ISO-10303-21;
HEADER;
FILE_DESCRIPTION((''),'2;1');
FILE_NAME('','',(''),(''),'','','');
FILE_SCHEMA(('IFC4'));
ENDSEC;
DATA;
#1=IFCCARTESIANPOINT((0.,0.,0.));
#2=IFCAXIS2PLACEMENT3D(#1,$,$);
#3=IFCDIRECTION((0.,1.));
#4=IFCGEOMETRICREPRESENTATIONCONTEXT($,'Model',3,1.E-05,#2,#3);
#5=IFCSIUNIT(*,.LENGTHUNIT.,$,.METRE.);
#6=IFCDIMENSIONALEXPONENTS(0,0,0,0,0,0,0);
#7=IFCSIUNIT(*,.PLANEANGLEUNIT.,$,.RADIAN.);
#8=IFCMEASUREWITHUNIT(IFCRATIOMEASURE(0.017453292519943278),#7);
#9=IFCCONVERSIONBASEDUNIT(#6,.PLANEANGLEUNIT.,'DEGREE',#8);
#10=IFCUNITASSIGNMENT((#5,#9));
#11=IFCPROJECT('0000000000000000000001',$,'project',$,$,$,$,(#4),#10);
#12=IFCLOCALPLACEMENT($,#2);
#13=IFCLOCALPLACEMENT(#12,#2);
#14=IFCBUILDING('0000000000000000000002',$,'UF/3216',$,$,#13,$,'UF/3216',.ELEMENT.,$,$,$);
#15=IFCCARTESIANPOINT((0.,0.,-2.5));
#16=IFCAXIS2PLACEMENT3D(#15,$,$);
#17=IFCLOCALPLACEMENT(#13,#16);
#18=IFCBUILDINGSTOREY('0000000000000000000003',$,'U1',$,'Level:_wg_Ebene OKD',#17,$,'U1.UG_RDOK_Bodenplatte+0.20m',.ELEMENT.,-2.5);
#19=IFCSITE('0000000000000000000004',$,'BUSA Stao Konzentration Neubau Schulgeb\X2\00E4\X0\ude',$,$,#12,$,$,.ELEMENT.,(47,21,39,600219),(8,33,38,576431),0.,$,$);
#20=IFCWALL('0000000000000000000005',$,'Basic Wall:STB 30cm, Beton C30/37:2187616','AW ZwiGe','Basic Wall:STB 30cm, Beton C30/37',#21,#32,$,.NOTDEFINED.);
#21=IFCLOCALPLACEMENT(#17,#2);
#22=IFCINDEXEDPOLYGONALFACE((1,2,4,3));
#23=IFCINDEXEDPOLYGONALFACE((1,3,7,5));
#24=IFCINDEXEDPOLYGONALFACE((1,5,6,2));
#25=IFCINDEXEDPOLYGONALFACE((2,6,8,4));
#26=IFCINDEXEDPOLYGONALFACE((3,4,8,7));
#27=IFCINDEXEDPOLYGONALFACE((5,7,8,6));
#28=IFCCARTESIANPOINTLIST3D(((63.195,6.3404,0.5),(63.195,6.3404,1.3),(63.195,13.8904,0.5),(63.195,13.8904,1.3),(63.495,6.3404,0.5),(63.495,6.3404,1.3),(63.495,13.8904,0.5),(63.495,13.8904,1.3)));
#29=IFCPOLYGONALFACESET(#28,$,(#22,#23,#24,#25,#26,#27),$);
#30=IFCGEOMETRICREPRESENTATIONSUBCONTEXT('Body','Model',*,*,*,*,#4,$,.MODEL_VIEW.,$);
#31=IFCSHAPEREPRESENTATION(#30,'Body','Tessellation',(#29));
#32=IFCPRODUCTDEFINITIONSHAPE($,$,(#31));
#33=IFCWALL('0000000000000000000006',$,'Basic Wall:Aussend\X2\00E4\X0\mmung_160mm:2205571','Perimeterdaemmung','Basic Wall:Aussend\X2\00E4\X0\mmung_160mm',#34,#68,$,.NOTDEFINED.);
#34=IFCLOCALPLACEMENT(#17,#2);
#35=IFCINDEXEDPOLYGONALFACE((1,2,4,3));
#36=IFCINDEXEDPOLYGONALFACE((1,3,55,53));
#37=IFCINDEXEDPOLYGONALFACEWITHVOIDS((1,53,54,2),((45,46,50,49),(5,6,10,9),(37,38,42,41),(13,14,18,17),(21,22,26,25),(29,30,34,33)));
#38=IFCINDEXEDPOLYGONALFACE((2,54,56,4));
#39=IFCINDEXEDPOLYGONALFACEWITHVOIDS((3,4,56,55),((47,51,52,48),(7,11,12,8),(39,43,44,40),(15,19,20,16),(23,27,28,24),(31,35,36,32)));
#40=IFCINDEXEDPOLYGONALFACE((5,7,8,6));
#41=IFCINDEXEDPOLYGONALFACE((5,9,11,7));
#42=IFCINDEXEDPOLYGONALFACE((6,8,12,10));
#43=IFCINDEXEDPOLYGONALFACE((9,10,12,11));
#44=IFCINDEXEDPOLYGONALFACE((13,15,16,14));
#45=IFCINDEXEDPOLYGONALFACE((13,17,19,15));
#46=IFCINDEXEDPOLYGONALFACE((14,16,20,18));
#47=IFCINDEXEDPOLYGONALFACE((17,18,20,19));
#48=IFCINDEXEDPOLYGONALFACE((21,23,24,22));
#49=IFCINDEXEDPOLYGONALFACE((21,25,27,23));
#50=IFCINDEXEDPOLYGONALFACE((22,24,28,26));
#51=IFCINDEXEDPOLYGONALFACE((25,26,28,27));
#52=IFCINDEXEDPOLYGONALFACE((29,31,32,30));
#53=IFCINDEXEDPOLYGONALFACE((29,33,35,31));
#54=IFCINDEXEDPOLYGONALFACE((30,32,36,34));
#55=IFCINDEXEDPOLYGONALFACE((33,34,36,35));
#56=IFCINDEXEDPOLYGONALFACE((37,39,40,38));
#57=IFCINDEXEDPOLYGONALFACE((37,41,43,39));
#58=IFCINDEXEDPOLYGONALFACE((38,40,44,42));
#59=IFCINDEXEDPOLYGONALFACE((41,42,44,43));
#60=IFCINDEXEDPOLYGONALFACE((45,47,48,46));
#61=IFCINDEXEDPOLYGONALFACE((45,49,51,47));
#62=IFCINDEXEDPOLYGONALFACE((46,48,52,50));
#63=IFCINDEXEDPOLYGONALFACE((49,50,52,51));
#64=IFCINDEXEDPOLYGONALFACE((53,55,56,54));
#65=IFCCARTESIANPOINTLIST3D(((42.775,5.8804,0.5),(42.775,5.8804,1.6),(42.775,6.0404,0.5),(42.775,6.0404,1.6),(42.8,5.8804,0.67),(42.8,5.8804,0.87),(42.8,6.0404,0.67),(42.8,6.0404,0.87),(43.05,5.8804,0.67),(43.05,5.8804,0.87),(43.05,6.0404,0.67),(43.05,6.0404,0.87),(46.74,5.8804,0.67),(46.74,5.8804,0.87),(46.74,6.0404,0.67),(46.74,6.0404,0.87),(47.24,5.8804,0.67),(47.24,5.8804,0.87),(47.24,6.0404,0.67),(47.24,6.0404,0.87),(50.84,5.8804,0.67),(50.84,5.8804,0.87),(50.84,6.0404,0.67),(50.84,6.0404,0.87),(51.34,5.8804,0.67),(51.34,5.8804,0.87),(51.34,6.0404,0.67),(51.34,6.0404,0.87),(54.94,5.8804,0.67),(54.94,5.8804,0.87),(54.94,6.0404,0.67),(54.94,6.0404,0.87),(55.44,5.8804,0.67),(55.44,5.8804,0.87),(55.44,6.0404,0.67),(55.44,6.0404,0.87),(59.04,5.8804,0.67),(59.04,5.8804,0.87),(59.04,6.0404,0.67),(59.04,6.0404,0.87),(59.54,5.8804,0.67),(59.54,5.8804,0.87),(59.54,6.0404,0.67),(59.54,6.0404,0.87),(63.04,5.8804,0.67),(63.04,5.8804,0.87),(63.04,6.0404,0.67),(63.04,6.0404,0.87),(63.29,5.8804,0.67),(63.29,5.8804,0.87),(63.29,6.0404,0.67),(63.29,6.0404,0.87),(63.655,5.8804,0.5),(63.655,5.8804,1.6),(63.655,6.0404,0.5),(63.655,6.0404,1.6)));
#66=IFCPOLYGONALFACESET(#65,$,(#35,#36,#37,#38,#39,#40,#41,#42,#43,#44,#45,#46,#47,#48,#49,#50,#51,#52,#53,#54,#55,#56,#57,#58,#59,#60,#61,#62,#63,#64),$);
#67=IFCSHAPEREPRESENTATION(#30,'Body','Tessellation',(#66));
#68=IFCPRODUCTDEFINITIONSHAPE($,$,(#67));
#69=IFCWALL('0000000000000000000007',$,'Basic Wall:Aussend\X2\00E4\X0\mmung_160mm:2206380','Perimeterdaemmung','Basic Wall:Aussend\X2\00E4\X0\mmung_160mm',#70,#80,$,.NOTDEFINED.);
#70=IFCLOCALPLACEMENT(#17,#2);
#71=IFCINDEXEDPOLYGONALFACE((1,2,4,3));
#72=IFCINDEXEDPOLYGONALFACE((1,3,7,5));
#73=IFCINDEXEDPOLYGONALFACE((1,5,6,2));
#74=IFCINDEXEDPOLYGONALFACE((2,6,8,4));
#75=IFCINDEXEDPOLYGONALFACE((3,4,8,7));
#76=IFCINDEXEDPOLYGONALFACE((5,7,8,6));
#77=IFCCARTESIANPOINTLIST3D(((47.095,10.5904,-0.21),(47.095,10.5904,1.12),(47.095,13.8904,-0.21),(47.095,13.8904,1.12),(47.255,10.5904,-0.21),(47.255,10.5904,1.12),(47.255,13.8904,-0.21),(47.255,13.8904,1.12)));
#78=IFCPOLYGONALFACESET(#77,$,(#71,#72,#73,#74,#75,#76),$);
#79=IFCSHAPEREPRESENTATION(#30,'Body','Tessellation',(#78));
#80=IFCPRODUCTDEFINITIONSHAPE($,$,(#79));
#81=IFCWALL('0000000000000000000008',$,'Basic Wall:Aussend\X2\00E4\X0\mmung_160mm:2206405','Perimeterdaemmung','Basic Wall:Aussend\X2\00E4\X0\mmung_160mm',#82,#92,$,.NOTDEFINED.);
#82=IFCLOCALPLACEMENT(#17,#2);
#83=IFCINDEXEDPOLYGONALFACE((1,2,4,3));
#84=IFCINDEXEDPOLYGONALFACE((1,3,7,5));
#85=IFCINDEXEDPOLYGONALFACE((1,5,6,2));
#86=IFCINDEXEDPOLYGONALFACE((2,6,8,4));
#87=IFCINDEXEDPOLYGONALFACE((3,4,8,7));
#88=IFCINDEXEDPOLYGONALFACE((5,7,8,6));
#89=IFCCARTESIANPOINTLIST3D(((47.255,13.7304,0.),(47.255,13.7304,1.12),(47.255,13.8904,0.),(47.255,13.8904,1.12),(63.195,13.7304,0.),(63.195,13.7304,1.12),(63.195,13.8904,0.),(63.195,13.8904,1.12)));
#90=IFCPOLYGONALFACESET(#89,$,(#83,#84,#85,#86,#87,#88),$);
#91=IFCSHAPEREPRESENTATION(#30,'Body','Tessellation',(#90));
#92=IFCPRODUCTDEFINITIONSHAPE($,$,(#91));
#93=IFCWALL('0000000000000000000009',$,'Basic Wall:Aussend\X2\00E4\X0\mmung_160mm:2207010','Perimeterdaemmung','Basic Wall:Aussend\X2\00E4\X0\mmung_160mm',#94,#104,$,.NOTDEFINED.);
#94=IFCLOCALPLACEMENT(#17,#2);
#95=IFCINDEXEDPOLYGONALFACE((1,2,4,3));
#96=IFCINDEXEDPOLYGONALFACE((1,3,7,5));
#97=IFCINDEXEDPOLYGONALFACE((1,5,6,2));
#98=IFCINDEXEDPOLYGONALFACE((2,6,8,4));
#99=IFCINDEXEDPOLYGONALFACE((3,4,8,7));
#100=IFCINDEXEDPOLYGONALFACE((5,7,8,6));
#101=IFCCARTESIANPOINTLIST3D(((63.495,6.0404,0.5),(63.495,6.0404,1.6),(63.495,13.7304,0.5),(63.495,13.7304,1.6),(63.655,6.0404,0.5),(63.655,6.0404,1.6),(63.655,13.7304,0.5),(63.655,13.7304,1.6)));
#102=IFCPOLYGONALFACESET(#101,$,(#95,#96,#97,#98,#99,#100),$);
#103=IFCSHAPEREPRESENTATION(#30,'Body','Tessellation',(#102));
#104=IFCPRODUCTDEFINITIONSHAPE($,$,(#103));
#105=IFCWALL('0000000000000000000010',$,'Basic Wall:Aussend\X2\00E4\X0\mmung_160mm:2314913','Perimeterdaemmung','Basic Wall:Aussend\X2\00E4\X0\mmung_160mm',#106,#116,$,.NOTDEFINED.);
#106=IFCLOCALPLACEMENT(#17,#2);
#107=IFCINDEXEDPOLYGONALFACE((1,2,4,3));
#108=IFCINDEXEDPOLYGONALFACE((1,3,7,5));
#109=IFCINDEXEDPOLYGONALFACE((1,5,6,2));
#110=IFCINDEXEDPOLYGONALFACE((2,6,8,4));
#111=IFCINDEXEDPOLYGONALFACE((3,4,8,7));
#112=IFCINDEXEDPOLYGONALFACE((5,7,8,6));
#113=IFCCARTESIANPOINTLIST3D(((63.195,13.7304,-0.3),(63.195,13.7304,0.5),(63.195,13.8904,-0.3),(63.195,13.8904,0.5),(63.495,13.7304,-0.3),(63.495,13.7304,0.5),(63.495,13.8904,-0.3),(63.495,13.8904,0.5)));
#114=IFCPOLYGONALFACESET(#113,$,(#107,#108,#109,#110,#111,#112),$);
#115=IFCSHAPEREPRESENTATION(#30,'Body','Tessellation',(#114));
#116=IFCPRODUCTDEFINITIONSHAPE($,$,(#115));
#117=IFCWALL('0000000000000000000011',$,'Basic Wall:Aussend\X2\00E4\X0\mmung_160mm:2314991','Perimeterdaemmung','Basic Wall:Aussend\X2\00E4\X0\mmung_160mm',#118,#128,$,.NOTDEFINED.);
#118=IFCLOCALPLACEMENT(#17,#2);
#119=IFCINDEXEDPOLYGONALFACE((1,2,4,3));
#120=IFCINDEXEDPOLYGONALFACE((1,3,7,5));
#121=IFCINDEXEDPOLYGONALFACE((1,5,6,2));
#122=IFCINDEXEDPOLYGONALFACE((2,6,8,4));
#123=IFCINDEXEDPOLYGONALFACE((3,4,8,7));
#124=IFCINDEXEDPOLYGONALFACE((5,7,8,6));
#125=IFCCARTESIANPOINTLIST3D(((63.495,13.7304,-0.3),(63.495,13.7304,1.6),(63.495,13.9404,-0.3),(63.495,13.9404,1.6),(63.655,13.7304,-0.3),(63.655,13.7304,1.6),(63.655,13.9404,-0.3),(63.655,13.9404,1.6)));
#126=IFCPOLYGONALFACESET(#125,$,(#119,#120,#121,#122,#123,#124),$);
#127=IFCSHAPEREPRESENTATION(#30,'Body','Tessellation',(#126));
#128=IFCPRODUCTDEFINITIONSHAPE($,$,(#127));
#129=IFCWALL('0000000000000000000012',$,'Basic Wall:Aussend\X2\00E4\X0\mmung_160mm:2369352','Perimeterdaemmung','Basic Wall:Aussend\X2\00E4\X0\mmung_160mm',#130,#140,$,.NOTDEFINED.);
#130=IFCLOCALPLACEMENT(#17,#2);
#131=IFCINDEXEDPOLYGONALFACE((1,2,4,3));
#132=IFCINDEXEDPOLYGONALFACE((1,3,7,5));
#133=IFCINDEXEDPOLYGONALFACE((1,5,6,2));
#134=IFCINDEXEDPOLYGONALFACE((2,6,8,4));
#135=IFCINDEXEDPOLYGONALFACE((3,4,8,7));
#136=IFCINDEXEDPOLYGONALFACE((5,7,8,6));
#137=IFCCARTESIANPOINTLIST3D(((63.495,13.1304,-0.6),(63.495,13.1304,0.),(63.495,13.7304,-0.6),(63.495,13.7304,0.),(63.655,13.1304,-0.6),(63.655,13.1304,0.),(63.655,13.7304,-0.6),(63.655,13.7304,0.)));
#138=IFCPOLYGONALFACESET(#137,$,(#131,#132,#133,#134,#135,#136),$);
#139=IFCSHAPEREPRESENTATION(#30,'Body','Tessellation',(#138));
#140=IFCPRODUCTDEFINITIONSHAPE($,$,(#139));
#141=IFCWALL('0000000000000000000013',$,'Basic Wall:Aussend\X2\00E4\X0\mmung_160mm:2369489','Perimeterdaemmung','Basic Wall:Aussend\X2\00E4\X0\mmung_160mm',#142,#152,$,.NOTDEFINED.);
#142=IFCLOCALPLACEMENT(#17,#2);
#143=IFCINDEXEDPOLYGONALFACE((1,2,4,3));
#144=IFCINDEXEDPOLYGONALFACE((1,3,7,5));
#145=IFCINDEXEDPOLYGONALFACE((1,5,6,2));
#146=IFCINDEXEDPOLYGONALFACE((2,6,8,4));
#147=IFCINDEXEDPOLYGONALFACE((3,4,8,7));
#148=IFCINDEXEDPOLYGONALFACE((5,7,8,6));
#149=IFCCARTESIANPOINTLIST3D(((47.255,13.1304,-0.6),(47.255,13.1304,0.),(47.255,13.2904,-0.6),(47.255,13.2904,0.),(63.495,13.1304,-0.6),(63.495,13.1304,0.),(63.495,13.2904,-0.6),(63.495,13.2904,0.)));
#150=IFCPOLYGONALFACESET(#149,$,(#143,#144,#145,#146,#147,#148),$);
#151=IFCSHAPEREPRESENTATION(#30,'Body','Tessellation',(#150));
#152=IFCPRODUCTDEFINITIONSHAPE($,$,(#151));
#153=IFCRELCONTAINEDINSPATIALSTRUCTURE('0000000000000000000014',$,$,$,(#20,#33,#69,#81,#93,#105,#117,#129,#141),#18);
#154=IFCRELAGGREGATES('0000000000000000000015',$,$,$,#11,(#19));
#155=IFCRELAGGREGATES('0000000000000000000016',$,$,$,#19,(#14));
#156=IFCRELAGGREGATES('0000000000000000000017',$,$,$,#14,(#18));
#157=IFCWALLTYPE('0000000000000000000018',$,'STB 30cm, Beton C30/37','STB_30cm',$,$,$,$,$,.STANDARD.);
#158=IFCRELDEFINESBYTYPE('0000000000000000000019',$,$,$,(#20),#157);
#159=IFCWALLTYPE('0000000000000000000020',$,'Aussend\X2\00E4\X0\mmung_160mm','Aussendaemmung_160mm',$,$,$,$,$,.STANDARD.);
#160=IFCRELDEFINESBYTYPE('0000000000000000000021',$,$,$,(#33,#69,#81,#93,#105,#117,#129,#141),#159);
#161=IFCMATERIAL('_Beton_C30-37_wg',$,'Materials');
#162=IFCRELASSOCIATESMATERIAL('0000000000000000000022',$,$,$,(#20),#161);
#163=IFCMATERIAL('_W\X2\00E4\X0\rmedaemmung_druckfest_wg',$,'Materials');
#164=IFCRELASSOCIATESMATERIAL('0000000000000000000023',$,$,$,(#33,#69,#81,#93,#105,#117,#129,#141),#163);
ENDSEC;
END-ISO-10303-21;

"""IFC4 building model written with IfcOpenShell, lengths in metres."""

from ifc_helpers import new_model, entity, si_unit, converted_unit, direction, frame, origin, place, context, subcontext, project, spatial, indexed_curve, outline, extrude, material, type_object, element, save


model = new_model("IFC4")

# Units and contexts
model_context = context("Model", 3, precision=1e-05, world=origin(), true_north=direction((0.0, 1.0)))
body_context = subcontext(model_context, "Body", "Model", "MODEL_VIEW")
ifc_project = project(units=[si_unit("LENGTHUNIT", "METRE"), converted_unit("PLANEANGLEUNIT", "DEGREE", entity("IfcRatioMeasure", 0.017453292519943278), si_unit("PLANEANGLEUNIT", "RADIAN"), dimensions=[0, 0, 0, 0, 0, 0, 0])], contexts=[model_context])

# Site, building, storey
site_placement = place(None, origin())
site = spatial("IfcSite", under=ifc_project, at=site_placement, Name="BUSA Stao Konzentration Neubau Schulgebäude", CompositionType="ELEMENT", RefLatitude=(47, 21, 39, 600219), RefLongitude=(8, 33, 38, 576431), RefElevation=0.0)
building_placement = place(site_placement, origin())
building = spatial("IfcBuilding", under=site, at=building_placement, Name="UF/3216", LongName="UF/3216", CompositionType="ELEMENT")
storey_placement = place(building_placement, frame((0.0, 0.0, -2.5)))
storey = spatial("IfcBuildingStorey", under=building, at=storey_placement, Name="U1", ObjectType="Level:_wg_Ebene OKD", LongName="U1.UG_RDOK_Bodenplatte+0.20m", CompositionType="ELEMENT", Elevation=-2.5)

# Wall
ifc_material_1 = material(Name="_Beton_C30-37_wg", Category="Materials")
wall_type_1 = type_object("IfcWallType", Name="STB 30cm, Beton C30/37", Description="STB_30cm", PredefinedType="STANDARD")
wall_1_placement = place(storey_placement, frame((63.345, 6.3404, 0.5), z_axis=(0.0, 0.0, 1.0), x_axis=(0.0, 1.0, 0.0)))
element("IfcWall", 1, at=wall_1_placement, inside=storey, type_object=wall_type_1, material=ifc_material_1, Name="Basic Wall:STB 30cm, Beton C30/37:2187616", Description="AW ZwiGe", ObjectType="Basic Wall:STB 30cm, Beton C30/37", PredefinedType="NOTDEFINED", context=body_context, shape_type="SweptSolid", body=[
    extrude(outline(indexed_curve([(7.55, 0.15), (0.0, 0.15), (0.0, -0.15), (7.55, -0.15), (7.55, 0.15)], self_intersect=False)), origin(), (0.0, 0.0, 1.0), 0.8),
])

# Wall, openings
ifc_material_2 = material(Name="_Wärmedaemmung_druckfest_wg", Category="Materials")
wall_type_2 = type_object("IfcWallType", Name="Aussendämmung_160mm", Description="Aussendaemmung_160mm", PredefinedType="STANDARD")
wall_2_placement = place(storey_placement, frame((63.655, 5.9604, 0.5), z_axis=(0.0, 0.0, 1.0), x_axis=(-1.0, 0.0, 0.0)))
wall_2 = element("IfcWall", 2, at=wall_2_placement, inside=storey, type_object=wall_type_2, material=ifc_material_2, Name="Basic Wall:Aussendämmung_160mm:2205571", Description="Perimeterdaemmung", ObjectType="Basic Wall:Aussendämmung_160mm", PredefinedType="NOTDEFINED", context=body_context, shape_type="SweptSolid", body=[
    extrude(outline(indexed_curve([(-0.064, -12.496), (0.096, -12.496), (0.096, 8.384), (-0.064, 8.384), (-0.064, 8.224), (-0.064, -12.496)], self_intersect=False)), frame((8.384, -0.016, 0.0), z_axis=(0.0, 0.0, 1.0), x_axis=(0.0, 1.0, 0.0)), (0.0, 0.0, 1.0), 1.1),
])
opening_1_placement = place(storey_placement, frame((63.655, 5.9604, 0.5), z_axis=(0.0, 0.0, 1.0), x_axis=(-1.0, 0.0, 0.0)))
element("IfcOpeningElement", 3, at=opening_1_placement, cuts=wall_2, PredefinedType="OPENING", context=body_context, shape_type="SweptSolid", body=[
    extrude(outline(indexed_curve([(-0.125, -0.1), (0.125, -0.1), (0.125, 0.1), (-0.125, 0.1), (-0.125, -0.1)], self_intersect=False)), frame((20.73, -0.08, 0.27), z_axis=(0.0, 1.0, 0.0), x_axis=(-1.0, 0.0, 0.0)), (0.0, 0.0, 1.0), 0.16),
])
opening_2_placement = place(storey_placement, frame((63.655, 5.9604, 0.5), z_axis=(0.0, 0.0, 1.0), x_axis=(-1.0, 0.0, 0.0)))
element("IfcOpeningElement", 4, at=opening_2_placement, cuts=wall_2, PredefinedType="OPENING", context=body_context, shape_type="SweptSolid", body=[
    extrude(outline(indexed_curve([(-0.125, -0.1), (0.125, -0.1), (0.125, 0.1), (-0.125, 0.1), (-0.125, -0.1)], self_intersect=False)), frame((0.49, -0.08, 0.27), z_axis=(0.0, 1.0, 0.0), x_axis=(-1.0, 0.0, 0.0)), (0.0, 0.0, 1.0), 0.16),
])
opening_3_placement = place(storey_placement, frame((63.655, 5.9604, 0.5), z_axis=(0.0, 0.0, 1.0), x_axis=(-1.0, 0.0, 0.0)))
element("IfcOpeningElement", 5, at=opening_3_placement, cuts=wall_2, PredefinedType="OPENING", context=body_context, shape_type="SweptSolid", body=[
    extrude(outline(indexed_curve([(-0.25, -0.1), (0.25, -0.1), (0.25, 0.1), (-0.25, 0.1), (-0.25, -0.1)], self_intersect=False)), frame((4.365, -0.08, 0.27), z_axis=(0.0, 1.0, 0.0), x_axis=(-1.0, 0.0, 0.0)), (0.0, 0.0, 1.0), 0.16),
])
opening_4_placement = place(storey_placement, frame((63.655, 5.9604, 0.5), z_axis=(0.0, 0.0, 1.0), x_axis=(-1.0, 0.0, 0.0)))
element("IfcOpeningElement", 6, at=opening_4_placement, cuts=wall_2, PredefinedType="OPENING", context=body_context, shape_type="SweptSolid", body=[
    extrude(outline(indexed_curve([(-0.25, -0.1), (0.25, -0.1), (0.25, 0.1), (-0.25, 0.1), (-0.25, -0.1)], self_intersect=False)), frame((8.465, -0.08, 0.27), z_axis=(0.0, 1.0, 0.0), x_axis=(-1.0, 0.0, 0.0)), (0.0, 0.0, 1.0), 0.16),
])
opening_5_placement = place(storey_placement, frame((63.655, 5.9604, 0.5), z_axis=(0.0, 0.0, 1.0), x_axis=(-1.0, 0.0, 0.0)))
element("IfcOpeningElement", 7, at=opening_5_placement, cuts=wall_2, PredefinedType="OPENING", context=body_context, shape_type="SweptSolid", body=[
    extrude(outline(indexed_curve([(-0.25, -0.1), (0.25, -0.1), (0.25, 0.1), (-0.25, 0.1), (-0.25, -0.1)], self_intersect=False)), frame((12.565, -0.08, 0.27), z_axis=(0.0, 1.0, 0.0), x_axis=(-1.0, 0.0, 0.0)), (0.0, 0.0, 1.0), 0.16),
])
opening_6_placement = place(storey_placement, frame((63.655, 5.9604, 0.5), z_axis=(0.0, 0.0, 1.0), x_axis=(-1.0, 0.0, 0.0)))
element("IfcOpeningElement", 8, at=opening_6_placement, cuts=wall_2, PredefinedType="OPENING", context=body_context, shape_type="SweptSolid", body=[
    extrude(outline(indexed_curve([(-0.25, -0.1), (0.25, -0.1), (0.25, 0.1), (-0.25, 0.1), (-0.25, -0.1)], self_intersect=False)), frame((16.665, -0.08, 0.27), z_axis=(0.0, 1.0, 0.0), x_axis=(-1.0, 0.0, 0.0)), (0.0, 0.0, 1.0), 0.16),
])

# Walls
wall_3_placement = place(storey_placement, frame((47.175, 13.8904, -0.21), z_axis=(0.0, 0.0, 1.0), x_axis=(0.0, -1.0, 0.0)))
element("IfcWall", 9, at=wall_3_placement, inside=storey, type_object=wall_type_2, material=ifc_material_2, Name="Basic Wall:Aussendämmung_160mm:2206380", Description="Perimeterdaemmung", ObjectType="Basic Wall:Aussendämmung_160mm", PredefinedType="NOTDEFINED", context=body_context, shape_type="SweptSolid", body=[
    extrude(outline(indexed_curve([(3.3, 0.08), (0.0, 0.08), (0.0, -0.08), (3.3, -0.08), (3.3, 0.08)], self_intersect=False)), origin(), (0.0, 0.0, 1.0), 1.33),
])
wall_4_placement = place(storey_placement, frame((63.195, 13.8104, 0.0), z_axis=(0.0, 0.0, 1.0), x_axis=(-1.0, 0.0, 0.0)))
element("IfcWall", 10, at=wall_4_placement, inside=storey, type_object=wall_type_2, material=ifc_material_2, Name="Basic Wall:Aussendämmung_160mm:2206405", Description="Perimeterdaemmung", ObjectType="Basic Wall:Aussendämmung_160mm", PredefinedType="NOTDEFINED", context=body_context, shape_type="SweptSolid", body=[
    extrude(outline(indexed_curve([(15.94, 0.08), (0.0, 0.08), (0.0, -0.08), (15.94, -0.08), (15.94, 0.08)], self_intersect=False)), origin(), (0.0, 0.0, 1.0), 1.12),
])
wall_5_placement = place(storey_placement, frame((63.575, 13.7304, 0.5), z_axis=(0.0, 0.0, 1.0), x_axis=(0.0, -1.0, 0.0)))
element("IfcWall", 11, at=wall_5_placement, inside=storey, type_object=wall_type_2, material=ifc_material_2, Name="Basic Wall:Aussendämmung_160mm:2207010", Description="Perimeterdaemmung", ObjectType="Basic Wall:Aussendämmung_160mm", PredefinedType="NOTDEFINED", context=body_context, shape_type="SweptSolid", body=[
    extrude(outline(indexed_curve([(7.69, 0.08), (0.0, 0.08), (0.0, -0.08), (7.69, -0.08), (7.69, 0.08)], self_intersect=False)), origin(), (0.0, 0.0, 1.0), 1.1),
])
wall_6_placement = place(storey_placement, frame((63.495, 13.8104, -0.3), z_axis=(0.0, 0.0, 1.0), x_axis=(-1.0, 0.0, 0.0)))
element("IfcWall", 12, at=wall_6_placement, inside=storey, type_object=wall_type_2, material=ifc_material_2, Name="Basic Wall:Aussendämmung_160mm:2314913", Description="Perimeterdaemmung", ObjectType="Basic Wall:Aussendämmung_160mm", PredefinedType="NOTDEFINED", context=body_context, shape_type="SweptSolid", body=[
    extrude(outline(indexed_curve([(0.3, 0.08), (0.0, 0.08), (0.0, -0.08), (0.3, -0.08), (0.3, 0.08)], self_intersect=False)), origin(), (0.0, 0.0, 1.0), 0.8),
])
wall_7_placement = place(storey_placement, frame((63.575, 13.9404, -0.3), z_axis=(0.0, 0.0, 1.0), x_axis=(0.0, -1.0, 0.0)))
element("IfcWall", 13, at=wall_7_placement, inside=storey, type_object=wall_type_2, material=ifc_material_2, Name="Basic Wall:Aussendämmung_160mm:2314991", Description="Perimeterdaemmung", ObjectType="Basic Wall:Aussendämmung_160mm", PredefinedType="NOTDEFINED", context=body_context, shape_type="SweptSolid", body=[
    extrude(outline(indexed_curve([(0.21, 0.08), (0.0, 0.08), (0.0, -0.08), (0.21, -0.08), (0.21, 0.08)], self_intersect=False)), origin(), (0.0, 0.0, 1.0), 1.9),
])
wall_8_placement = place(storey_placement, frame((63.575, 13.7304, -0.6), z_axis=(0.0, 0.0, 1.0), x_axis=(0.0, -1.0, 0.0)))
element("IfcWall", 14, at=wall_8_placement, inside=storey, type_object=wall_type_2, material=ifc_material_2, Name="Basic Wall:Aussendämmung_160mm:2369352", Description="Perimeterdaemmung", ObjectType="Basic Wall:Aussendämmung_160mm", PredefinedType="NOTDEFINED", context=body_context, shape_type="SweptSolid", body=[
    extrude(outline(indexed_curve([(0.6, 0.08), (0.0, 0.08), (0.0, -0.08), (0.6, -0.08), (0.6, 0.08)], self_intersect=False)), origin(), (0.0, 0.0, 1.0), 0.6),
])
wall_9_placement = place(storey_placement, frame((63.495, 13.2104, -0.6), z_axis=(0.0, 0.0, 1.0), x_axis=(-1.0, 0.0, 0.0)))
element("IfcWall", 15, at=wall_9_placement, inside=storey, type_object=wall_type_2, material=ifc_material_2, Name="Basic Wall:Aussendämmung_160mm:2369489", Description="Perimeterdaemmung", ObjectType="Basic Wall:Aussendämmung_160mm", PredefinedType="NOTDEFINED", context=body_context, shape_type="SweptSolid", body=[
    extrude(outline(indexed_curve([(16.24, 0.08), (0.0, 0.08), (0.0, -0.08), (16.24, -0.08), (16.24, 0.08)], self_intersect=False)), origin(), (0.0, 0.0, 1.0), 0.6),
])

save(model, "model.ifc")
